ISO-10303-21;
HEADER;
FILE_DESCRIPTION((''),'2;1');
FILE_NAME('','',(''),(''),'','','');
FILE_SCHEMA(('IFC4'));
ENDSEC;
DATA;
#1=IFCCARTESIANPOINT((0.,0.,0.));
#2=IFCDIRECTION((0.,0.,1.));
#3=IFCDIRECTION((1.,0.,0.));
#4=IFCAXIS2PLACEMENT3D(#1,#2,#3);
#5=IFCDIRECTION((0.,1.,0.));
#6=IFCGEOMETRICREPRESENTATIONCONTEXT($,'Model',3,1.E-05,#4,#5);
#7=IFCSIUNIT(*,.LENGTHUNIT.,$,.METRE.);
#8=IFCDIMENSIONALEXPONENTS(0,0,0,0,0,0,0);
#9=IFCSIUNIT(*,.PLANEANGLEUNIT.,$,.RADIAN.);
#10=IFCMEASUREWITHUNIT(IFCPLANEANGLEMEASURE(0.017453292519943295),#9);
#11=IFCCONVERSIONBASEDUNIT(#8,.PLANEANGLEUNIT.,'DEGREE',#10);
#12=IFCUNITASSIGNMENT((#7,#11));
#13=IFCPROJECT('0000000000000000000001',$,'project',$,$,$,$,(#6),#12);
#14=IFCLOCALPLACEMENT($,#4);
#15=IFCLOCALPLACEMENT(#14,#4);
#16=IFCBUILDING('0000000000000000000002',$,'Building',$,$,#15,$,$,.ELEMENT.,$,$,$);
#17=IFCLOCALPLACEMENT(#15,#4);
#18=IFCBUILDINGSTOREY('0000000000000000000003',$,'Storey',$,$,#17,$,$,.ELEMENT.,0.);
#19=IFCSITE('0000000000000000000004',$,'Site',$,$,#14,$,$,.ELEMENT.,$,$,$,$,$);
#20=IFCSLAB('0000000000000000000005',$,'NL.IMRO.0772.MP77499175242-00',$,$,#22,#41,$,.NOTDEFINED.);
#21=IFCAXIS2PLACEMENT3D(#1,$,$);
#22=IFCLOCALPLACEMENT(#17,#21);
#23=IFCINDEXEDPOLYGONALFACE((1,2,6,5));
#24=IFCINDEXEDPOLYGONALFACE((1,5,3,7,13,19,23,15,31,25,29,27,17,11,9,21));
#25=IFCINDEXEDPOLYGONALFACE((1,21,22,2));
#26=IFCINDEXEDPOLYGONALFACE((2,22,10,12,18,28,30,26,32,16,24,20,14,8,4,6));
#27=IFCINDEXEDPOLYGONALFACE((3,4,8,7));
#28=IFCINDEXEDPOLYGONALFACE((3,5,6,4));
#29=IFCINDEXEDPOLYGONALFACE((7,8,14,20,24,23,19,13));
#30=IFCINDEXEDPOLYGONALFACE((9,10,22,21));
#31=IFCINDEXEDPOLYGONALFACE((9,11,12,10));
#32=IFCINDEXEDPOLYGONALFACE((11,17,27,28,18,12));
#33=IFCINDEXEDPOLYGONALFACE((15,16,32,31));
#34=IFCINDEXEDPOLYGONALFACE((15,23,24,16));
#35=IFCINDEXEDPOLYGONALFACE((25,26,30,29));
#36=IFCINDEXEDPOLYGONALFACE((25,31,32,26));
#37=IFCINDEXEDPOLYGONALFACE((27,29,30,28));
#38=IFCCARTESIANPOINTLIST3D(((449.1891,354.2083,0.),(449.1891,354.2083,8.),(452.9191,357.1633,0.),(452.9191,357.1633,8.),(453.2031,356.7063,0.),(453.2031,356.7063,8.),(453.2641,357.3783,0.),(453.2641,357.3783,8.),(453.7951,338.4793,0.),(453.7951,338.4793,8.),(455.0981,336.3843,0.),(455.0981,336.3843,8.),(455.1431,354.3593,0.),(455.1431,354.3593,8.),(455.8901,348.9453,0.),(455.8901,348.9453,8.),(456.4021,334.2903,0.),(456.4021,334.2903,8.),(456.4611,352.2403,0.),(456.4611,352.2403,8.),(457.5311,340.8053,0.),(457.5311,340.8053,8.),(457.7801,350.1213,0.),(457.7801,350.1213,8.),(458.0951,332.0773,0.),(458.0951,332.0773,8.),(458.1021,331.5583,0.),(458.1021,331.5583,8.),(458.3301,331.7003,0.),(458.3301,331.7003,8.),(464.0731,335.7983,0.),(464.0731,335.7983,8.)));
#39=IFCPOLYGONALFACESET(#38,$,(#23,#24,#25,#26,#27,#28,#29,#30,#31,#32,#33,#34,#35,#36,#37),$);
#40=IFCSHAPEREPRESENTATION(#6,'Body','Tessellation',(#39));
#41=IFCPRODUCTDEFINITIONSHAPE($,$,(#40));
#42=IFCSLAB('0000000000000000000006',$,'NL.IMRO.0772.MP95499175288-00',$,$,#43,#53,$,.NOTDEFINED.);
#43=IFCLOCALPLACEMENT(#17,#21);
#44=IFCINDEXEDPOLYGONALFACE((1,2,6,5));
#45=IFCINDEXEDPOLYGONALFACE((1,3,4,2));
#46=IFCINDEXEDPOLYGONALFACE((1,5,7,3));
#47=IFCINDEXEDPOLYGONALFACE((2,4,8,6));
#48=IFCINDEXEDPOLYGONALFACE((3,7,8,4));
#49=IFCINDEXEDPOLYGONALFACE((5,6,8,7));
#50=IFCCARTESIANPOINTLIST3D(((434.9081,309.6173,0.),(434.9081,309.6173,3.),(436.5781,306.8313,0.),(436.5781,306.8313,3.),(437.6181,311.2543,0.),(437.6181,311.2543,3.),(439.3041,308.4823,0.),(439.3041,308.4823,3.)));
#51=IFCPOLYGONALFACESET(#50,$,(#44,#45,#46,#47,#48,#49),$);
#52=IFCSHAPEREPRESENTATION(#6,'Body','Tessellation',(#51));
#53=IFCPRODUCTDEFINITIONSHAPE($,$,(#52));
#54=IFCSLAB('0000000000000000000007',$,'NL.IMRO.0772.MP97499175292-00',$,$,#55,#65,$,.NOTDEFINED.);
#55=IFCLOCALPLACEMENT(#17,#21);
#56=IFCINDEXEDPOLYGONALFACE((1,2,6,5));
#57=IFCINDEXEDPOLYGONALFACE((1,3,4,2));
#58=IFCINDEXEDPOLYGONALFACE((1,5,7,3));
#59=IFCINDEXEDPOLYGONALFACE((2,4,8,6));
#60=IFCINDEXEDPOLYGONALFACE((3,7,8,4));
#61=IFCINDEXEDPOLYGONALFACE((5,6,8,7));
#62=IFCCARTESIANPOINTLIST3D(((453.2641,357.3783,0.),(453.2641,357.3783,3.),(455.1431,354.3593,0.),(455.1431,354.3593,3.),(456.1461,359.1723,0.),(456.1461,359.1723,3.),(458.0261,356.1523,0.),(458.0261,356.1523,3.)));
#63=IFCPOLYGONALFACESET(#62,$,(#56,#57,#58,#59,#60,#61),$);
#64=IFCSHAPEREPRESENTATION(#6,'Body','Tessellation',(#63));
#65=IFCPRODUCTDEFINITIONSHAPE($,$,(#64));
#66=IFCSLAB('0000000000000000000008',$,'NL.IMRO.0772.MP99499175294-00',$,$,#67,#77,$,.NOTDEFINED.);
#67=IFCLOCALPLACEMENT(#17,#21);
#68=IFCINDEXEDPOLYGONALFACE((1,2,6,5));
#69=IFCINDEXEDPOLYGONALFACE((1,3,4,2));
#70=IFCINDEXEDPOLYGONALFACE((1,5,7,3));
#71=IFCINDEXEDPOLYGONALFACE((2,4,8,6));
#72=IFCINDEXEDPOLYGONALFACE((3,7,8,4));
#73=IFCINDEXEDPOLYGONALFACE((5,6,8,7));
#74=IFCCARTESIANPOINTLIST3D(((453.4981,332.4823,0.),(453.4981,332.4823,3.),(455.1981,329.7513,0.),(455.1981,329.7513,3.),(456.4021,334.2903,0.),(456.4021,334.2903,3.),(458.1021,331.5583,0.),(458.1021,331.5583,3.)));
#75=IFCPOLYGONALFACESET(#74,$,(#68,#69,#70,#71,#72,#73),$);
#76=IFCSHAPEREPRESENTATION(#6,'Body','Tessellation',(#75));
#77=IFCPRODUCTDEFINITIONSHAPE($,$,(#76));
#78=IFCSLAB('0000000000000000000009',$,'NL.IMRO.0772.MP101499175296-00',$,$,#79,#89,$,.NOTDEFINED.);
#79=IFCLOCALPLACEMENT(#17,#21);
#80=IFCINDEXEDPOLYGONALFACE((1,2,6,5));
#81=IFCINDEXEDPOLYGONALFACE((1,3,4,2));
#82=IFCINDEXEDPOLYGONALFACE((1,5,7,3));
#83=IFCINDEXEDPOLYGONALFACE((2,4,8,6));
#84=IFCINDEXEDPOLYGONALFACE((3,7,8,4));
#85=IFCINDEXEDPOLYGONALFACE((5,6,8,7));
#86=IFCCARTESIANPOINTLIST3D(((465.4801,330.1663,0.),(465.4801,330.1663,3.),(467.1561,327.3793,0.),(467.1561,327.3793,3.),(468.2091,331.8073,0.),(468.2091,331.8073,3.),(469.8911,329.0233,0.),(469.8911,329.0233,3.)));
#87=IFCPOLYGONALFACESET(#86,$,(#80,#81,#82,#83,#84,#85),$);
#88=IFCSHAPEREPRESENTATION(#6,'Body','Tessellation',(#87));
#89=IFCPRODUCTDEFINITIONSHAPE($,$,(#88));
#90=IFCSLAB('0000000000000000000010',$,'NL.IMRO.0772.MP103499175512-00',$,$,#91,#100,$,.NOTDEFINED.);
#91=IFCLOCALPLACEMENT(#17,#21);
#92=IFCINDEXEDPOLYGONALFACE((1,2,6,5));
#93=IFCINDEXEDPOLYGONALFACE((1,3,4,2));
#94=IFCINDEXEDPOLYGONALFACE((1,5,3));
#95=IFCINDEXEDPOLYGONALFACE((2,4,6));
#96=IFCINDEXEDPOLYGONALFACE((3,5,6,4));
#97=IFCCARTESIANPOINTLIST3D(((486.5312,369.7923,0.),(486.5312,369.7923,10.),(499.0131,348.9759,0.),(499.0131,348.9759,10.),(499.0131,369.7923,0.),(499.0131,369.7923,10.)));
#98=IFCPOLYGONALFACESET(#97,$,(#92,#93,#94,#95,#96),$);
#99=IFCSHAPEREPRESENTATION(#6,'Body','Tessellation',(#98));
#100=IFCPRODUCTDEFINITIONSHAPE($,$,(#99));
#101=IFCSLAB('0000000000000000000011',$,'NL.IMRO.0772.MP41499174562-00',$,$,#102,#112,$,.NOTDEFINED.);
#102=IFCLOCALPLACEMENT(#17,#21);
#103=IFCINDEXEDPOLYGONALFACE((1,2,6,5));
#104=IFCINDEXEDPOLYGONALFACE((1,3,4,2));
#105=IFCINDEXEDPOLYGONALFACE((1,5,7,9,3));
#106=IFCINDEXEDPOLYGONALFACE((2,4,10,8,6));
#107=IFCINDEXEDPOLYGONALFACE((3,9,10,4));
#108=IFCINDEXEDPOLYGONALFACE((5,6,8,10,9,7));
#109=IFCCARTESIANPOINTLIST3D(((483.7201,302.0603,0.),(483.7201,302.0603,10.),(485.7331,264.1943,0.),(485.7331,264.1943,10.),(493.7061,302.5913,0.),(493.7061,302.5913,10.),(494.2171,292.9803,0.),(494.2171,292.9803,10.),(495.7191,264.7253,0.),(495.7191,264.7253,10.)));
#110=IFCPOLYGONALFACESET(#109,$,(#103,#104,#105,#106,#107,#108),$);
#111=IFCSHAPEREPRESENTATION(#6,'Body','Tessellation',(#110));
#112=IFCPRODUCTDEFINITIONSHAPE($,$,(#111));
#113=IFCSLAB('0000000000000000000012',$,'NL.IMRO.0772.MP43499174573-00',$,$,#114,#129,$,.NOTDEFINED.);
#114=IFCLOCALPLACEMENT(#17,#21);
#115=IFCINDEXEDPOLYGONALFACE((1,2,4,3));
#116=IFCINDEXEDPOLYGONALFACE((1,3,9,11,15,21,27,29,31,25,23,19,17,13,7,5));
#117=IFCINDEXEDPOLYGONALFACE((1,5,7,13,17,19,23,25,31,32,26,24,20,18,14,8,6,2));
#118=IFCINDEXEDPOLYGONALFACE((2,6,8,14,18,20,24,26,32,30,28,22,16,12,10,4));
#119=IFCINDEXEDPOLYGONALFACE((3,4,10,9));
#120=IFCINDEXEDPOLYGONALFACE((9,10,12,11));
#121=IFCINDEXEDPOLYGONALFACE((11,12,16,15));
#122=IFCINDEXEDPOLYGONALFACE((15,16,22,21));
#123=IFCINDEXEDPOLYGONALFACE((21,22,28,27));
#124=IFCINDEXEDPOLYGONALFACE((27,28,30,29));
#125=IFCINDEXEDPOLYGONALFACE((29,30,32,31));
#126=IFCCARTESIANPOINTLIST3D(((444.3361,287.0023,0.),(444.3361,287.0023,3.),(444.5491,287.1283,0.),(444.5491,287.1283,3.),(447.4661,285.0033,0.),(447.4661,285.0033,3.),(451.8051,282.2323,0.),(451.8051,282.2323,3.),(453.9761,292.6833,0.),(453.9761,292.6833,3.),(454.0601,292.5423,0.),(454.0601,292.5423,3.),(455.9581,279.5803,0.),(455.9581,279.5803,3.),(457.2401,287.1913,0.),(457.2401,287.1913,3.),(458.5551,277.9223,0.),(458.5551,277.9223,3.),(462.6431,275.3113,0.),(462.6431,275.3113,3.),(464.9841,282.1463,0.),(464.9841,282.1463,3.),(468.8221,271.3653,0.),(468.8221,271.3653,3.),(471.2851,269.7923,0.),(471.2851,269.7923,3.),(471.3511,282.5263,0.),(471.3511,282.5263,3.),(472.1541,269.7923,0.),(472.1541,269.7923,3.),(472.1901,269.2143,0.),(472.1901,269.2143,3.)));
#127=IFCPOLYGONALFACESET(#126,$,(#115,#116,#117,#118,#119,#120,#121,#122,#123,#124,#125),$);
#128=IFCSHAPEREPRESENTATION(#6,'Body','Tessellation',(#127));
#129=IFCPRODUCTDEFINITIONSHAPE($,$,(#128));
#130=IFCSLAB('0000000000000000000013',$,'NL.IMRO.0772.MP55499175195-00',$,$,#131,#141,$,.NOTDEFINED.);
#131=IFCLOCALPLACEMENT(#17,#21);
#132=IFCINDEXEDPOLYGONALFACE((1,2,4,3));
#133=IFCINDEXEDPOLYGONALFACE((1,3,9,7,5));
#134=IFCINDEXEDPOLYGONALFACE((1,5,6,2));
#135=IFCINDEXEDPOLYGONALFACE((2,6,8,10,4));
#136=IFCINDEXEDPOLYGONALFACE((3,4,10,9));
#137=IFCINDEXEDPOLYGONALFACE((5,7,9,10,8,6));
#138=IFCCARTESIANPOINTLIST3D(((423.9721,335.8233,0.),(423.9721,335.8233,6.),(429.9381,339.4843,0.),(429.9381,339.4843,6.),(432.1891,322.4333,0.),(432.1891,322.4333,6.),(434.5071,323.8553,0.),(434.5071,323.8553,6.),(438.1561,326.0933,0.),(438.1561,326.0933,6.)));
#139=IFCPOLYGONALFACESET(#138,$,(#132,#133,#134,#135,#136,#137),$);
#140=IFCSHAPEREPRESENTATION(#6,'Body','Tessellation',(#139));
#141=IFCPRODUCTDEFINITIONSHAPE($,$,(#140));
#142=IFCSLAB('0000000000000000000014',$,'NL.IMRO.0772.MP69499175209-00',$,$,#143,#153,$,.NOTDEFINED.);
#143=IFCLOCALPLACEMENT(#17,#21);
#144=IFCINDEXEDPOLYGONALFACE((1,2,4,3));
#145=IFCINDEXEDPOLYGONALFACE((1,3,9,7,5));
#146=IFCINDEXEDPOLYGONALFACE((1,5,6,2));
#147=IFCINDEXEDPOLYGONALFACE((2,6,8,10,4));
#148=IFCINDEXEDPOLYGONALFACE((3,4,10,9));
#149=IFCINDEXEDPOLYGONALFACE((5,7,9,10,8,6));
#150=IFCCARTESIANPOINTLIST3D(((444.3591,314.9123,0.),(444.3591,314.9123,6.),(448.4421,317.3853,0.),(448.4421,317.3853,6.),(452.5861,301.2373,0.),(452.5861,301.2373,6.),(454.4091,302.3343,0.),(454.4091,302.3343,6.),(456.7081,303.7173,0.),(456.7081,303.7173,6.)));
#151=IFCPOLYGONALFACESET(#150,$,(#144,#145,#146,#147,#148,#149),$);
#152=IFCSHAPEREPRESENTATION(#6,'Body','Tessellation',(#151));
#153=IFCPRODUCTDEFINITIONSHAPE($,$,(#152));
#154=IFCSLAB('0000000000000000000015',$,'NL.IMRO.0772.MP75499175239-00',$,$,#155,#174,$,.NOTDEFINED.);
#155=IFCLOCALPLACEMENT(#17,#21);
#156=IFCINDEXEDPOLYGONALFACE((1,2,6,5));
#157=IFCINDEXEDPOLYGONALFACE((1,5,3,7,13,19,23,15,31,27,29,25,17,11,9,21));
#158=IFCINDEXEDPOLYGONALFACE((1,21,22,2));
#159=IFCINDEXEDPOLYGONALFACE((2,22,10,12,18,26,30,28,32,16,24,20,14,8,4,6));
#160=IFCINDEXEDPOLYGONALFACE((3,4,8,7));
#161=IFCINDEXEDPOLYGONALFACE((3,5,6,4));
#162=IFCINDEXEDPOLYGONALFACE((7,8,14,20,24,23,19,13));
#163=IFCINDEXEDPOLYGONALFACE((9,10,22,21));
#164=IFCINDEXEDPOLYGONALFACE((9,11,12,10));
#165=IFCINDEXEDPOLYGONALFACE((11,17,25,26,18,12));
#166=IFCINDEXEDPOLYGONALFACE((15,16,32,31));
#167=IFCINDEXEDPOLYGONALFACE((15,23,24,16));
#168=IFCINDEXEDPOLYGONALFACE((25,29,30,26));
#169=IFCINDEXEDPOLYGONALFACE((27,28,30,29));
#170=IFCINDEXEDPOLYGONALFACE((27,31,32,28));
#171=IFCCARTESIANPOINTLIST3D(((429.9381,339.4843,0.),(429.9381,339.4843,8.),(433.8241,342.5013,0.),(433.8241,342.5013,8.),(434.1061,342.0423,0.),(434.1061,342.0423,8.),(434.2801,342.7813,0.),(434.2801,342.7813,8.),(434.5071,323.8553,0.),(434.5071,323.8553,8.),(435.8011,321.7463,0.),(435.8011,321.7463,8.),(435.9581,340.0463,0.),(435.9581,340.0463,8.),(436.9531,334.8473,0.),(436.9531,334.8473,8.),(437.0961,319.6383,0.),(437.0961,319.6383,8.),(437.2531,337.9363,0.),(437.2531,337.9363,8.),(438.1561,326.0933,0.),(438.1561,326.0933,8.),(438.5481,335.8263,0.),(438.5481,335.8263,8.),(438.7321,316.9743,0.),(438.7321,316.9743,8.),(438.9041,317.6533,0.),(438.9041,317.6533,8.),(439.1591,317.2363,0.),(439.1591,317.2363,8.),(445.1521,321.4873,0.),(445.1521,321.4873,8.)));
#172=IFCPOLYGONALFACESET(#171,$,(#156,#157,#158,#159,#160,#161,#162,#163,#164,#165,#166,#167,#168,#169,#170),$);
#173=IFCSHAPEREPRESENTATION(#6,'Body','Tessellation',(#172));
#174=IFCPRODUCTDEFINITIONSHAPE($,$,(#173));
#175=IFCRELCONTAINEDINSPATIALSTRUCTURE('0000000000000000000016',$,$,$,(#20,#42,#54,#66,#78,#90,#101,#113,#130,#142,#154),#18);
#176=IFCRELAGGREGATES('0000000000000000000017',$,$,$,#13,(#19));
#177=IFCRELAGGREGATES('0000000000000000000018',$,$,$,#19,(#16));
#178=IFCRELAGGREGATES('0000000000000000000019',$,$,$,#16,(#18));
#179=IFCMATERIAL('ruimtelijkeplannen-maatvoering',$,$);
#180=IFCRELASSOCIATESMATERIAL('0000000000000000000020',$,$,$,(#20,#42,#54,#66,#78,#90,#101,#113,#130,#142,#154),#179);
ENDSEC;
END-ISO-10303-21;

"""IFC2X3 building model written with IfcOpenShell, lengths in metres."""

from ifc_helpers import new_model, entity, si_unit, converted_unit, direction, origin_with_axes, place, context, project, spatial, polyline, outline, extrude, material, element, save


model = new_model("IFC2X3")

# Units and contexts
model_context = context("Model", 3, precision=1e-05, world=origin_with_axes(), true_north=direction((0.0, 1.0, 0.0)))
ifc_project = project(units=[si_unit("LENGTHUNIT", "METRE"), converted_unit("PLANEANGLEUNIT", "DEGREE", entity("IfcPlaneAngleMeasure", 0.017453292519943295), si_unit("PLANEANGLEUNIT", "RADIAN"), dimensions=[0, 0, 0, 0, 0, 0, 0])], contexts=[model_context])

# Site, building, storey
site_placement = place(None, origin_with_axes())
site = spatial("IfcSite", under=ifc_project, at=site_placement, Name="Site", CompositionType="ELEMENT")
building_placement = place(site_placement, origin_with_axes())
building = spatial("IfcBuilding", under=site, at=building_placement, Name="Building", CompositionType="ELEMENT")
storey_placement = place(building_placement, origin_with_axes())
storey = spatial("IfcBuildingStorey", under=building, at=storey_placement, Name="Storey", CompositionType="ELEMENT", Elevation=0.0)

# Slabs
ifc_material = material(Name="ruimtelijkeplannen-maatvoering")
slab_1_placement = place(storey_placement, origin_with_axes())
element("IfcSlab", 1, at=slab_1_placement, inside=storey, material=ifc_material, Name="NL.IMRO.0772.MP77499175242-00", PredefinedType="NOTDEFINED", context=model_context, shape_type="SweptSolid", body=[
    extrude(outline(polyline([(455.8901, 348.9453), (464.0731, 335.7983), (458.0951, 332.0773), (458.3301, 331.7003), (458.1021, 331.5583), (456.4021, 334.2903), (455.0981, 336.3843), (453.7951, 338.4793), (457.5311, 340.8053), (449.1891, 354.2083), (453.2031, 356.7063), (452.9191, 357.1633), (453.2641, 357.3783), (455.1431, 354.3593), (456.4611, 352.2403), (457.7801, 350.1213), (455.8901, 348.9453)])), origin_with_axes(), (0.0, 0.0, 1.0), 8.0),
])
slab_2_placement = place(storey_placement, origin_with_axes())
element("IfcSlab", 2, at=slab_2_placement, inside=storey, material=ifc_material, Name="NL.IMRO.0772.MP95499175288-00", PredefinedType="NOTDEFINED", context=model_context, shape_type="SweptSolid", body=[
    extrude(outline(polyline([(437.6181, 311.2543), (439.3041, 308.4823), (436.5781, 306.8313), (434.9081, 309.6173), (437.6181, 311.2543)])), origin_with_axes(), (0.0, 0.0, 1.0), 3.0),
])
slab_3_placement = place(storey_placement, origin_with_axes())
element("IfcSlab", 3, at=slab_3_placement, inside=storey, material=ifc_material, Name="NL.IMRO.0772.MP97499175292-00", PredefinedType="NOTDEFINED", context=model_context, shape_type="SweptSolid", body=[
    extrude(outline(polyline([(453.2641, 357.3783), (456.1461, 359.1723), (458.0261, 356.1523), (455.1431, 354.3593), (453.2641, 357.3783)])), origin_with_axes(), (0.0, 0.0, 1.0), 3.0),
])
slab_4_placement = place(storey_placement, origin_with_axes())
element("IfcSlab", 4, at=slab_4_placement, inside=storey, material=ifc_material, Name="NL.IMRO.0772.MP99499175294-00", PredefinedType="NOTDEFINED", context=model_context, shape_type="SweptSolid", body=[
    extrude(outline(polyline([(458.1021, 331.5583), (455.1981, 329.7513), (453.4981, 332.4823), (456.4021, 334.2903), (458.1021, 331.5583)])), origin_with_axes(), (0.0, 0.0, 1.0), 3.0),
])
slab_5_placement = place(storey_placement, origin_with_axes())
element("IfcSlab", 5, at=slab_5_placement, inside=storey, material=ifc_material, Name="NL.IMRO.0772.MP101499175296-00", PredefinedType="NOTDEFINED", context=model_context, shape_type="SweptSolid", body=[
    extrude(outline(polyline([(465.4801, 330.1663), (468.2091, 331.8073), (469.8911, 329.0233), (467.1561, 327.3793), (465.4801, 330.1663)])), origin_with_axes(), (0.0, 0.0, 1.0), 3.0),
])
slab_6_placement = place(storey_placement, origin_with_axes())
element("IfcSlab", 6, at=slab_6_placement, inside=storey, material=ifc_material, Name="NL.IMRO.0772.MP103499175512-00", PredefinedType="NOTDEFINED", context=model_context, shape_type="SweptSolid", body=[
    extrude(outline(polyline([(486.5312, 369.7923), (499.0131, 369.7923), (499.0131, 348.9759), (486.5312, 369.7923)])), origin_with_axes(), (0.0, 0.0, 1.0), 10.0),
])
slab_7_placement = place(storey_placement, origin_with_axes())
element("IfcSlab", 7, at=slab_7_placement, inside=storey, material=ifc_material, Name="NL.IMRO.0772.MP41499174562-00", PredefinedType="NOTDEFINED", context=model_context, shape_type="SweptSolid", body=[
    extrude(outline(polyline([(485.7331, 264.1943), (483.7201, 302.0603), (493.7061, 302.5913), (494.2171, 292.9803), (495.7191, 264.7253), (485.7331, 264.1943)])), origin_with_axes(), (0.0, 0.0, 1.0), 10.0),
])
slab_8_placement = place(storey_placement, origin_with_axes())
element("IfcSlab", 8, at=slab_8_placement, inside=storey, material=ifc_material, Name="NL.IMRO.0772.MP43499174573-00", PredefinedType="NOTDEFINED", context=model_context, shape_type="SweptSolid", body=[
    extrude(outline(polyline([(472.1541, 269.7923), (472.1901, 269.2143), (471.2851, 269.7923), (468.8221, 271.3653), (462.6431, 275.3113), (458.5551, 277.9223), (455.9581, 279.5803), (451.8051, 282.2323), (447.4661, 285.0033), (444.3361, 287.0023), (444.5491, 287.1283), (453.9761, 292.6833), (454.0601, 292.5423), (457.2401, 287.1913), (464.9841, 282.1463), (471.3511, 282.5263), (472.1541, 269.7923)])), origin_with_axes(), (0.0, 0.0, 1.0), 3.0),
])
slab_9_placement = place(storey_placement, origin_with_axes())
element("IfcSlab", 9, at=slab_9_placement, inside=storey, material=ifc_material, Name="NL.IMRO.0772.MP55499175195-00", PredefinedType="NOTDEFINED", context=model_context, shape_type="SweptSolid", body=[
    extrude(outline(polyline([(429.9381, 339.4843), (438.1561, 326.0933), (434.5071, 323.8553), (432.1891, 322.4333), (423.9721, 335.8233), (429.9381, 339.4843)])), origin_with_axes(), (0.0, 0.0, 1.0), 6.0),
])
slab_10_placement = place(storey_placement, origin_with_axes())
element("IfcSlab", 10, at=slab_10_placement, inside=storey, material=ifc_material, Name="NL.IMRO.0772.MP69499175209-00", PredefinedType="NOTDEFINED", context=model_context, shape_type="SweptSolid", body=[
    extrude(outline(polyline([(444.3591, 314.9123), (448.4421, 317.3853), (456.7081, 303.7173), (454.4091, 302.3343), (452.5861, 301.2373), (444.3591, 314.9123)])), origin_with_axes(), (0.0, 0.0, 1.0), 6.0),
])
slab_11_placement = place(storey_placement, origin_with_axes())
element("IfcSlab", 11, at=slab_11_placement, inside=storey, material=ifc_material, Name="NL.IMRO.0772.MP75499175239-00", PredefinedType="NOTDEFINED", context=model_context, shape_type="SweptSolid", body=[
    extrude(outline(polyline([(438.7321, 316.9743), (437.0961, 319.6383), (435.8011, 321.7463), (434.5071, 323.8553), (438.1561, 326.0933), (429.9381, 339.4843), (434.1061, 342.0423), (433.8241, 342.5013), (434.2801, 342.7813), (435.9581, 340.0463), (437.2531, 337.9363), (438.5481, 335.8263), (436.9531, 334.8473), (445.1521, 321.4873), (438.9041, 317.6533), (439.1591, 317.2363), (438.7321, 316.9743)])), origin_with_axes(), (0.0, 0.0, 1.0), 8.0),
])

save(model, "model.ifc")
